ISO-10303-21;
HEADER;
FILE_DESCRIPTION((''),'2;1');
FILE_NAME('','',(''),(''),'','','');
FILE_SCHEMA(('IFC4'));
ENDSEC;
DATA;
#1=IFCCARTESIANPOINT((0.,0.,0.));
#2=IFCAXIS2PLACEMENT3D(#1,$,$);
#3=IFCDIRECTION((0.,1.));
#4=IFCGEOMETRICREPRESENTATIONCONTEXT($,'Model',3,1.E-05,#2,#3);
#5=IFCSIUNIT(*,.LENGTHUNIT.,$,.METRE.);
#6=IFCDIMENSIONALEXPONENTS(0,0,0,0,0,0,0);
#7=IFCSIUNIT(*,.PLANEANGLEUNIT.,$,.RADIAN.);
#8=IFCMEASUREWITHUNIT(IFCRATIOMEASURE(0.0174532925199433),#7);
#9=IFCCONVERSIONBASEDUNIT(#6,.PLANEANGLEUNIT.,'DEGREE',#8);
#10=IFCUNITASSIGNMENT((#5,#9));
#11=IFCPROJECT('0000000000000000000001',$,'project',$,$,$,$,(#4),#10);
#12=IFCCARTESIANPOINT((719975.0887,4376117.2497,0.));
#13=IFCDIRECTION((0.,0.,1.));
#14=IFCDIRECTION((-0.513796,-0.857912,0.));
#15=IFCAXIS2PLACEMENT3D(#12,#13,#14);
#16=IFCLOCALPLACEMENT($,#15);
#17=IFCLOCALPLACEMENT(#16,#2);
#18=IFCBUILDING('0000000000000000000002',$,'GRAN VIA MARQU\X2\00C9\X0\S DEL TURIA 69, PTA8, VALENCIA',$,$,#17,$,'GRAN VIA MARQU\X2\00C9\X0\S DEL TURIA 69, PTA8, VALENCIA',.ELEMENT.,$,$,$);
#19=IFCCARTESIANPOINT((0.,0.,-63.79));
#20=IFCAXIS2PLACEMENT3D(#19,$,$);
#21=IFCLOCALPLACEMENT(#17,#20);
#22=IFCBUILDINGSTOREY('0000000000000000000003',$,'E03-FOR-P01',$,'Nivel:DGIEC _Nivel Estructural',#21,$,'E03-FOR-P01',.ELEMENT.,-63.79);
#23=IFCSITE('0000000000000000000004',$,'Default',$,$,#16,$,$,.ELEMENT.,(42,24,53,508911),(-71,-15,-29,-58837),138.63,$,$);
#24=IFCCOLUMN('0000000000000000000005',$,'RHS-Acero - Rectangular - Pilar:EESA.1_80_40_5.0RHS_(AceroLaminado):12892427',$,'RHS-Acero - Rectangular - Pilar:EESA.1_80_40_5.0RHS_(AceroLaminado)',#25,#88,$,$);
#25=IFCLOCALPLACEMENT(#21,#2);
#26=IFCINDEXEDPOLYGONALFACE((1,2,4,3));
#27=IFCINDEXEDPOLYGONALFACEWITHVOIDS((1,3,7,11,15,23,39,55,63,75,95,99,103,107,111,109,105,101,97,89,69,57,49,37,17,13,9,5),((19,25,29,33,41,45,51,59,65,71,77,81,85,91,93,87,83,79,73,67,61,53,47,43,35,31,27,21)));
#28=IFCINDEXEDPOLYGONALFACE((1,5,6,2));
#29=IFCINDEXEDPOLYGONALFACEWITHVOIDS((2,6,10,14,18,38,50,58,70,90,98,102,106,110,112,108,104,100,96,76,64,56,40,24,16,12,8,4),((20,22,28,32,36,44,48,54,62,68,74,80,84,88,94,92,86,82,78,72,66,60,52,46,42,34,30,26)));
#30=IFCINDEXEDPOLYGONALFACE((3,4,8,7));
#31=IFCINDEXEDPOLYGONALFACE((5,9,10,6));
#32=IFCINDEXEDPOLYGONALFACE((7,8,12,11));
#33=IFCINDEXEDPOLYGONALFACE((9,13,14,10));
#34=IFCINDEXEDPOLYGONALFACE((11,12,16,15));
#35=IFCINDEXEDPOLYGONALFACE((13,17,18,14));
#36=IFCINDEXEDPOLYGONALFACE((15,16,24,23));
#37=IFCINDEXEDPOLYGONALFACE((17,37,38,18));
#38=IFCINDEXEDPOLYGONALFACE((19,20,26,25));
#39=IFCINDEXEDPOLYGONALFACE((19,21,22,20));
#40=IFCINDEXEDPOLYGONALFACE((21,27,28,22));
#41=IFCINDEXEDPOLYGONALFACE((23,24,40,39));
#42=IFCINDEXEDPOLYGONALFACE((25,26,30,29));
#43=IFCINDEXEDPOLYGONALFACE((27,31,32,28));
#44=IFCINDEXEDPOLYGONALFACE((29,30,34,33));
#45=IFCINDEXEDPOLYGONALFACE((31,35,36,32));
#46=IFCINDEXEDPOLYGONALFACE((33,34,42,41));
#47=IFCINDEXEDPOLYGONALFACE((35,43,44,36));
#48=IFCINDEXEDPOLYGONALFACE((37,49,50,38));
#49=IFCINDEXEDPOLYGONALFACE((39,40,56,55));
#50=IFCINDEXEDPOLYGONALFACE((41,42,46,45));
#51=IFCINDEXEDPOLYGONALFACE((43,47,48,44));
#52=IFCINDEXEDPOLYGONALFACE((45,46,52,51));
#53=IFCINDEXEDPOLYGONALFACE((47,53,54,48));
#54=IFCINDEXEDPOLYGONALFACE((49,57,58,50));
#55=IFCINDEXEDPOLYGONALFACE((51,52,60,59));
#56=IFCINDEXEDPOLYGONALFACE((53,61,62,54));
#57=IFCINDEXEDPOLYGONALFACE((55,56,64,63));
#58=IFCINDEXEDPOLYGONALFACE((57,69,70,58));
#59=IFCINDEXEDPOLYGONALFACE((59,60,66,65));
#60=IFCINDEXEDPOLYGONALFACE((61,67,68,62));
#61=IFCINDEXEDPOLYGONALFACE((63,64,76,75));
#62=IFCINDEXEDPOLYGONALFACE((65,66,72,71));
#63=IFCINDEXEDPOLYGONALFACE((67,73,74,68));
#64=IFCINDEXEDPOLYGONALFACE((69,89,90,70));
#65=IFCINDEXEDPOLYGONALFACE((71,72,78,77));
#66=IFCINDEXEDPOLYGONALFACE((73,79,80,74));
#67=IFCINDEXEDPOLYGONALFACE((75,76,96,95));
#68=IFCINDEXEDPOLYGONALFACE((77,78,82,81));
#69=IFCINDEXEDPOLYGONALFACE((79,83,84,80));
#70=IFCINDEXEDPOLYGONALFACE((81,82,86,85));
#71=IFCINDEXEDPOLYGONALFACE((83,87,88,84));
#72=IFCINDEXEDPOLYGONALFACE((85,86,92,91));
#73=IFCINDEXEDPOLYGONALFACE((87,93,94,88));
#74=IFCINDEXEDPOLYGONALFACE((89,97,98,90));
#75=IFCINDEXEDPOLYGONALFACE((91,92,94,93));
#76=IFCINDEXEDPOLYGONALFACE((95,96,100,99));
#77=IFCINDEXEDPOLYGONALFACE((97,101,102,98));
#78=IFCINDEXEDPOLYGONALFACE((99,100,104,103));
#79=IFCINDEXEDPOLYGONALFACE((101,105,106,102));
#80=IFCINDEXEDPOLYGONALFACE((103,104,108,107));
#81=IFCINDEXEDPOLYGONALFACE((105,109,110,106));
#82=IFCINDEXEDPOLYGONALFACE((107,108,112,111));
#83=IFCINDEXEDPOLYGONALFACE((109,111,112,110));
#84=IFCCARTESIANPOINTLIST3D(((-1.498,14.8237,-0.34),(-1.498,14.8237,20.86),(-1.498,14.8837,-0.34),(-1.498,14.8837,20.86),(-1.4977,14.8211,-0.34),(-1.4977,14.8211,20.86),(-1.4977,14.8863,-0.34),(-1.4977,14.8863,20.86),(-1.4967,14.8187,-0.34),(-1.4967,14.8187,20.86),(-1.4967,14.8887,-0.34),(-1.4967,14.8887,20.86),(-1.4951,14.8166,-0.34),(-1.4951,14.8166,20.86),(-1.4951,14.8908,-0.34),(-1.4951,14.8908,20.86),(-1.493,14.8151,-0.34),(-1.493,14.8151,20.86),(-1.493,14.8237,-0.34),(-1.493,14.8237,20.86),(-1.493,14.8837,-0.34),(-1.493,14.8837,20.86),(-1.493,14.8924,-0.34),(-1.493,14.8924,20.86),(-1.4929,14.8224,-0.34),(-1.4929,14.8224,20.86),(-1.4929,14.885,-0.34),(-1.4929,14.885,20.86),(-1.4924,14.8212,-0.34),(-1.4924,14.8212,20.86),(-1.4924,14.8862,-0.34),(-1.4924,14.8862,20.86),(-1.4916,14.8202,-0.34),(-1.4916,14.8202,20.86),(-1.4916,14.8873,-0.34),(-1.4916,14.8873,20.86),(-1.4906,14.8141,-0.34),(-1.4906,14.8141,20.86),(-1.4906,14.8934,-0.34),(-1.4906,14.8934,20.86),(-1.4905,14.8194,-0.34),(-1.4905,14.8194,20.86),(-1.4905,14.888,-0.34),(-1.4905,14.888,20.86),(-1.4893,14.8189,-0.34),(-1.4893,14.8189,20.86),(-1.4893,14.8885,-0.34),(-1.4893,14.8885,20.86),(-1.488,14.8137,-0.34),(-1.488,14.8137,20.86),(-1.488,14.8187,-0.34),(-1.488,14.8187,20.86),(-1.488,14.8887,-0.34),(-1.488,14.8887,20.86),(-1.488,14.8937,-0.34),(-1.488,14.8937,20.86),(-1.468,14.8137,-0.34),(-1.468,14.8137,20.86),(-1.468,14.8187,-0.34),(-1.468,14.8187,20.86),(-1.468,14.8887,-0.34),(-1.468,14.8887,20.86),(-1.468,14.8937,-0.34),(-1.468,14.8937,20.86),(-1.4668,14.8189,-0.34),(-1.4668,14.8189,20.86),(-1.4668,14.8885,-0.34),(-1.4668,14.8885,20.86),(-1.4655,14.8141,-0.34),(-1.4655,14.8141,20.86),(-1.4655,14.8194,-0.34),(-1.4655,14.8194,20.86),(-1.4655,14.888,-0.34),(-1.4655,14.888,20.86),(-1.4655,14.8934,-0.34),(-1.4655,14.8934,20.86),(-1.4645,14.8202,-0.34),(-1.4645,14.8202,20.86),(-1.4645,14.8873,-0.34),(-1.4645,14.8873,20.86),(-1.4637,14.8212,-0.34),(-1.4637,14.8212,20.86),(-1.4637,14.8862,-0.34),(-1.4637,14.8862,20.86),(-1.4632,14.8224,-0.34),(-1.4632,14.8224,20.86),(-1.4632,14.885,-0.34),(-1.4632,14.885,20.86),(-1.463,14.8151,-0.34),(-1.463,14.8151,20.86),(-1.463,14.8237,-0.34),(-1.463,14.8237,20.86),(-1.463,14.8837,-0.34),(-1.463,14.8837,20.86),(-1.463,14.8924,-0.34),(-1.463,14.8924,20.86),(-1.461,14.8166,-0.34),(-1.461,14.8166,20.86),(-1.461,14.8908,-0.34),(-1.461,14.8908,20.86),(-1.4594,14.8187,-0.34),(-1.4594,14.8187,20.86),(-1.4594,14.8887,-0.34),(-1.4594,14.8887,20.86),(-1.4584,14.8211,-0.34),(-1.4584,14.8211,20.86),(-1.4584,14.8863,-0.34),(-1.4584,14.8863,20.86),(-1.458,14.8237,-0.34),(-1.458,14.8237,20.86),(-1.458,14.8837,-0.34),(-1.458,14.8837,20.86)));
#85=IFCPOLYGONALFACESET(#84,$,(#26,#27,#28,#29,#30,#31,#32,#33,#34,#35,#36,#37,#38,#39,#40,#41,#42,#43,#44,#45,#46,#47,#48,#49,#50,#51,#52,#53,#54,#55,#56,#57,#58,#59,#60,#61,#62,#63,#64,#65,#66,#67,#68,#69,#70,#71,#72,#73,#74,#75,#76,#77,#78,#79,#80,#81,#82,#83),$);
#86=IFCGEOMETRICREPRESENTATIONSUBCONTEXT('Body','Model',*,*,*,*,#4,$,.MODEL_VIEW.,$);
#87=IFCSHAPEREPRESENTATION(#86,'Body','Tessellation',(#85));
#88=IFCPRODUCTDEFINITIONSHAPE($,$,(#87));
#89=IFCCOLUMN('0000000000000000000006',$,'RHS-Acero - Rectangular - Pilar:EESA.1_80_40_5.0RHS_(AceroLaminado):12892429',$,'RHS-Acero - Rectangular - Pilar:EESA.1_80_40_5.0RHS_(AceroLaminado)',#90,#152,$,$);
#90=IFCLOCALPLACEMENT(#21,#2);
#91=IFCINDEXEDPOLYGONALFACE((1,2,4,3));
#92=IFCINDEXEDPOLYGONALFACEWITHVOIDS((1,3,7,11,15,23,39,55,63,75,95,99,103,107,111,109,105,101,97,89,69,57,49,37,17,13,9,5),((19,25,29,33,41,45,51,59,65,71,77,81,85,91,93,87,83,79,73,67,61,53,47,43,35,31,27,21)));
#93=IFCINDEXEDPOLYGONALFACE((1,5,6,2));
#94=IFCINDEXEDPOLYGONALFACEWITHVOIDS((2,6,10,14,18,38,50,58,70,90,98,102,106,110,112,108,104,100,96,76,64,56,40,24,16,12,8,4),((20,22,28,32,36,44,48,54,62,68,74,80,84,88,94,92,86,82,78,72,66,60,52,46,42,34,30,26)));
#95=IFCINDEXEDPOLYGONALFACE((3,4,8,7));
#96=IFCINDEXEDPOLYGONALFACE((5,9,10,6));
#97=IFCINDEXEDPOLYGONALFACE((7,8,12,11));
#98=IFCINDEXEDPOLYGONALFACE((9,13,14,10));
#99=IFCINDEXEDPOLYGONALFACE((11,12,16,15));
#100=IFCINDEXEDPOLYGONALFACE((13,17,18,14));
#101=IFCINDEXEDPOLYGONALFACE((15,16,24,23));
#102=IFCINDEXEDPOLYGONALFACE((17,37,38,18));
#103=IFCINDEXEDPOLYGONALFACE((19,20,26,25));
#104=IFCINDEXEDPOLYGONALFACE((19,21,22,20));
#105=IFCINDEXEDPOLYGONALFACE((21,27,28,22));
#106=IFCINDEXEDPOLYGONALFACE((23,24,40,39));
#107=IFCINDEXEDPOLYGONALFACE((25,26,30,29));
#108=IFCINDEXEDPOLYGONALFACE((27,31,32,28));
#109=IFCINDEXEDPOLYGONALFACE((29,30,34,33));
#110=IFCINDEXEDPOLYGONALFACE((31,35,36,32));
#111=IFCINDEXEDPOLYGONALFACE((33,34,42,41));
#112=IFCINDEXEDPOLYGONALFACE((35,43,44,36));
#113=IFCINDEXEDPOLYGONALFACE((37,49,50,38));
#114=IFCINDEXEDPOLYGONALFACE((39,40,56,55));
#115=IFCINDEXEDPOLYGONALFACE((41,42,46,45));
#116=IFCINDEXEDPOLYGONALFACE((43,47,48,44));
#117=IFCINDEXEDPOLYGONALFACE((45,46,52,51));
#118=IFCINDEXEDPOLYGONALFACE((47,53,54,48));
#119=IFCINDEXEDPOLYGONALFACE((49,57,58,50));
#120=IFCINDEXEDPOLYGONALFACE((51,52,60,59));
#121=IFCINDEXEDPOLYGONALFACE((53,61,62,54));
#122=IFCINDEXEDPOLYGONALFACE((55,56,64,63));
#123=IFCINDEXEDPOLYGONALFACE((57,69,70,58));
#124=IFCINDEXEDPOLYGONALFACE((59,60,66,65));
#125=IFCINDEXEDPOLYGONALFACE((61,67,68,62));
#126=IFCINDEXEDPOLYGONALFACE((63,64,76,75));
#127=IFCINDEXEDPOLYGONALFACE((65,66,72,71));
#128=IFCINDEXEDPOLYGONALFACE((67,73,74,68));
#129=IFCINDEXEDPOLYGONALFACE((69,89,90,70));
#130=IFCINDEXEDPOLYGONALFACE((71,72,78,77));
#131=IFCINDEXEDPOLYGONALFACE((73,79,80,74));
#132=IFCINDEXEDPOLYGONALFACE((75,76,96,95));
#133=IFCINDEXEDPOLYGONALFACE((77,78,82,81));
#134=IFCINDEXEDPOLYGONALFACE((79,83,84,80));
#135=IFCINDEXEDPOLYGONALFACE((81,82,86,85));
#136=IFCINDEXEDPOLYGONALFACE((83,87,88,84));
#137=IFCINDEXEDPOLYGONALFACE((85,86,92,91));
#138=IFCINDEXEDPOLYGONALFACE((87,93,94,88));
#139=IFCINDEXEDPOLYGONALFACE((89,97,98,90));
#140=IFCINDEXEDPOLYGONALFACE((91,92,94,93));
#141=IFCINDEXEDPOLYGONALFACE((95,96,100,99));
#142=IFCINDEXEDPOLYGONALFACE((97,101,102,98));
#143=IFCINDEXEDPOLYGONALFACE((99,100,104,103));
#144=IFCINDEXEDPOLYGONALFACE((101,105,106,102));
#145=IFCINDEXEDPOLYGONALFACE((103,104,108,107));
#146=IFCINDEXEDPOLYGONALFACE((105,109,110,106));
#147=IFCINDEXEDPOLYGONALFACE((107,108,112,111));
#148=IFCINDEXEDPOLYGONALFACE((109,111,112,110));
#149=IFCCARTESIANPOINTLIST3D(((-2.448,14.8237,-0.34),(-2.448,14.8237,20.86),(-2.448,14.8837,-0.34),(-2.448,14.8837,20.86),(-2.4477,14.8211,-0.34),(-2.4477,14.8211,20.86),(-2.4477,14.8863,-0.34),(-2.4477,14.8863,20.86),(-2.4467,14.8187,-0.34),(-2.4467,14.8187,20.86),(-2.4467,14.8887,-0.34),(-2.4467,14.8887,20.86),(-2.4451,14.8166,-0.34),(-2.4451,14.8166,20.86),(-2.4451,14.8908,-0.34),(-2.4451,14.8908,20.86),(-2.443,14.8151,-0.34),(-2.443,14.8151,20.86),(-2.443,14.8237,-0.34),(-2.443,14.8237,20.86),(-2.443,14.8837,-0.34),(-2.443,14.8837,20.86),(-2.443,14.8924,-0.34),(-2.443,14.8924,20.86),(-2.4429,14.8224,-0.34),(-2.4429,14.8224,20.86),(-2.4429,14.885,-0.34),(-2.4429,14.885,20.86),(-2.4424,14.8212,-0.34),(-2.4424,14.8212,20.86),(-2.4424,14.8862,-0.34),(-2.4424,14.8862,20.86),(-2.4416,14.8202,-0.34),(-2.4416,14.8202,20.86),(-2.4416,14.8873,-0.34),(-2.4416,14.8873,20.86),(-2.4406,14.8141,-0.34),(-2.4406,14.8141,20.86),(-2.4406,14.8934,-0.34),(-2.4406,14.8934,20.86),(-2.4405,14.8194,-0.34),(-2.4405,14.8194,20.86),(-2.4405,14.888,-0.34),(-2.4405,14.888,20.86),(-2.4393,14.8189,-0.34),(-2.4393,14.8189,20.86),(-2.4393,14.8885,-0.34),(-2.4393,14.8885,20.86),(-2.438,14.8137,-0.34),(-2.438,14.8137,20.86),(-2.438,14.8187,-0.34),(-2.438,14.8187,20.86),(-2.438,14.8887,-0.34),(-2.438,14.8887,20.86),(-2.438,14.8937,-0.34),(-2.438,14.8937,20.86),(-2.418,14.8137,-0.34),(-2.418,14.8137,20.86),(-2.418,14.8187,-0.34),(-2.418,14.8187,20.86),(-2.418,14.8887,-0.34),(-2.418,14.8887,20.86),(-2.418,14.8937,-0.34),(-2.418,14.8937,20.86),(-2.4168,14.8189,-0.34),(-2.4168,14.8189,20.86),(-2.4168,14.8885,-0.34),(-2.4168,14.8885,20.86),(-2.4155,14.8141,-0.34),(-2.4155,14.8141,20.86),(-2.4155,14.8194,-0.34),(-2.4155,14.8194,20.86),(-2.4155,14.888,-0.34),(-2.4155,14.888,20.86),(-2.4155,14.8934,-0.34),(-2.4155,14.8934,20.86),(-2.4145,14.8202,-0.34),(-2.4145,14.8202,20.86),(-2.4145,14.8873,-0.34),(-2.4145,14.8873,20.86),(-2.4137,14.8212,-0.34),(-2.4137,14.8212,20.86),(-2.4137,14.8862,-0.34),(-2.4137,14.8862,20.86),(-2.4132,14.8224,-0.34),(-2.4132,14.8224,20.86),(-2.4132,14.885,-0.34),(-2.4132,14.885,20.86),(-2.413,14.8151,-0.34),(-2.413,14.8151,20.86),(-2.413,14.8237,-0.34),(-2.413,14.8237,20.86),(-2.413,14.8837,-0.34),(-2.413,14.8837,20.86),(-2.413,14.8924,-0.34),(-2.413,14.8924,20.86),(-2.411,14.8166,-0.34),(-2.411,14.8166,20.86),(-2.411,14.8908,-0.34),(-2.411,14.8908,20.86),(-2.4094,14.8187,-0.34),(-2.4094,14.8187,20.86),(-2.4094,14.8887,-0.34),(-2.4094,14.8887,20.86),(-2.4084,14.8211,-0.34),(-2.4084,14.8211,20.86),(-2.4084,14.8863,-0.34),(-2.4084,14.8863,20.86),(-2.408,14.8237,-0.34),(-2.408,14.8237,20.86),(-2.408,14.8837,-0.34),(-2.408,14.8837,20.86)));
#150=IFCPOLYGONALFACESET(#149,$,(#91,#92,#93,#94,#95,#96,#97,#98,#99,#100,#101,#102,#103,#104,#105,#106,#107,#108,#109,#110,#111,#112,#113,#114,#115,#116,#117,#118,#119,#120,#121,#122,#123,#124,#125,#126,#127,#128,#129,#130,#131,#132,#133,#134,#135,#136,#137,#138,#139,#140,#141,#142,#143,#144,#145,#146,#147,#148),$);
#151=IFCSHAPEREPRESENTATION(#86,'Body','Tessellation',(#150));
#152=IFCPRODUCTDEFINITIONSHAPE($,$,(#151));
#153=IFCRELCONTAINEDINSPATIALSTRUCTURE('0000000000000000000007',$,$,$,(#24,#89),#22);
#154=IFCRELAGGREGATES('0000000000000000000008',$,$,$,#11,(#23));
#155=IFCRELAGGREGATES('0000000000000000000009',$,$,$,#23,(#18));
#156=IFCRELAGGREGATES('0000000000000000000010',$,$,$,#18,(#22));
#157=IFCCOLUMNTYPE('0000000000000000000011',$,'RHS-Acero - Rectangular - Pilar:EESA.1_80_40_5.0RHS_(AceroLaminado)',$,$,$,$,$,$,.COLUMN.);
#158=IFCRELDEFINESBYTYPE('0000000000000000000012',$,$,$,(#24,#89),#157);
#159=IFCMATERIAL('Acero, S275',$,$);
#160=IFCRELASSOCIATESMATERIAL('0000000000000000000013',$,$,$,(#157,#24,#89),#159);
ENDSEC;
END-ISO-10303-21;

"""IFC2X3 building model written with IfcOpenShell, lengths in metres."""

from ifc_helpers import new_model, entity, si_unit, converted_unit, direction, frame, frame_2d, origin, place, context, subcontext, project, spatial, polyline, circle_curve, parameter, trimmed, segment, composite_curve, outline, extrude, source, transform, mapped, material, type_object, type_shapes, element, save


model = new_model("IFC2X3")

# Units and contexts
model_context = context("Model", 3, precision=1e-05, world=origin(), true_north=direction((0.0, 1.0)))
body_context = subcontext(model_context, "Body", "Model", "MODEL_VIEW")
ifc_project = project(units=[si_unit("LENGTHUNIT", "METRE"), converted_unit("PLANEANGLEUNIT", "DEGREE", entity("IfcRatioMeasure", 0.0174532925199433), si_unit("PLANEANGLEUNIT", "RADIAN"), dimensions=[0, 0, 0, 0, 0, 0, 0])], contexts=[model_context])

# Site, building, storey
site_placement = place(None, frame((719975.0887, 4376117.2497, 0.0), z_axis=(0.0, 0.0, 1.0), x_axis=(-0.513796, -0.857912, 0.0)))
site = spatial("IfcSite", under=ifc_project, at=site_placement, Name="Default", CompositionType="ELEMENT", RefLatitude=(42, 24, 53, 508911), RefLongitude=(-71, -15, -29, -58837), RefElevation=138.63)
building_placement = place(site_placement, origin())
building = spatial("IfcBuilding", under=site, at=building_placement, Name="GRAN VIA MARQUÉS DEL TURIA 69, PTA8, VALENCIA", LongName="GRAN VIA MARQUÉS DEL TURIA 69, PTA8, VALENCIA", CompositionType="ELEMENT")
storey_placement = place(building_placement, frame((0.0, 0.0, -63.79)))
storey = spatial("IfcBuildingStorey", under=building, at=storey_placement, Name="E03-FOR-P01", ObjectType="Nivel:DGIEC _Nivel Estructural", LongName="E03-FOR-P01", CompositionType="ELEMENT", Elevation=-63.79)

# Columns
ifc_material_1 = material(Name="Acero, S275")
column_type_1 = type_object("IfcColumnType", Name="RHS-Acero - Rectangular - Pilar:EESA.1_80_40_5.0RHS_(AceroLaminado)", PredefinedType="COLUMN", material=ifc_material_1)
shared_shape_1 = source(origin(), body_context, "Body", "SweptSolid", [
    extrude(outline(composite_curve([segment(polyline([(-0.01, -0.04), (0.01, -0.04)]), True, "CONTINUOUS"), segment(trimmed(circle_curve(frame_2d((0.01, -0.03), x_axis=(-1.0, 0.0)), 0.01), [parameter(90.0)], [parameter(180.0)], True, "PARAMETER"), True, "CONTINUOUS"), segment(polyline([(0.02, -0.03), (0.02, 0.03)]), True, "CONTINUOUS"), segment(trimmed(circle_curve(frame_2d((0.01, 0.03), x_axis=(-1.0, 0.0)), 0.01), [parameter(180.0)], [parameter(270.0)], True, "PARAMETER"), True, "CONTINUOUS"), segment(polyline([(0.01, 0.04), (-0.01, 0.04)]), True, "CONTINUOUS"), segment(trimmed(circle_curve(frame_2d((-0.01, 0.03), x_axis=(-1.0, 0.0)), 0.01), [parameter(270.0)], [parameter(360.0)], True, "PARAMETER"), True, "CONTINUOUS"), segment(polyline([(-0.02, 0.03), (-0.02, -0.03)]), True, "CONTINUOUS"), segment(trimmed(circle_curve(frame_2d((-0.01, -0.03), x_axis=(-1.0, 0.0)), 0.01), [parameter(360.0)], [parameter(90.0)], True, "PARAMETER"), True, "CONTINUOUS")], self_intersect=False), holes=[composite_curve([segment(trimmed(circle_curve(frame_2d((-0.01, -0.03), x_axis=(-1.0, 0.0)), 0.005), [parameter(0.0)], [parameter(90.0)], True, "PARAMETER"), False, "CONTINUOUS"), segment(polyline([(-0.015, -0.03), (-0.015, 0.03)]), True, "CONTINUOUS"), segment(trimmed(circle_curve(frame_2d((-0.01, 0.03), x_axis=(-1.0, 0.0)), 0.005), [parameter(270.0)], [parameter(0.0)], True, "PARAMETER"), False, "CONTINUOUS"), segment(polyline([(-0.01, 0.035), (0.01, 0.035)]), True, "CONTINUOUS"), segment(trimmed(circle_curve(frame_2d((0.01, 0.03), x_axis=(-1.0, 0.0)), 0.005), [parameter(180.0)], [parameter(270.0)], True, "PARAMETER"), False, "CONTINUOUS"), segment(polyline([(0.015, 0.03), (0.015, -0.03)]), True, "CONTINUOUS"), segment(trimmed(circle_curve(frame_2d((0.01, -0.03), x_axis=(-1.0, 0.0)), 0.005), [parameter(90.0)], [parameter(180.0)], True, "PARAMETER"), False, "CONTINUOUS"), segment(polyline([(0.01, -0.035), (-0.01, -0.035)]), True, "CONTINUOUS")], self_intersect=False)]), frame((0.0, 0.0, -64.13), z_axis=(0.0, 0.0, 1.0), x_axis=(-1.0, 0.0, 0.0)), (0.0, 0.0, 1.0), 21.2),
])
type_shapes(column_type_1, [shared_shape_1])
for number, where, z_axis, x_axis, name in (
    (1, (-1.478, 14.8537, 63.79), (0.0, 0.0, 1.0), (-1.0, 0.0, 0.0), "RHS-Acero - Rectangular - Pilar:EESA.1_80_40_5.0RHS_(AceroLaminado):12892427"),
    (2, (-2.428, 14.8537, 63.79), (0.0, 0.0, 1.0), (-1.0, 0.0, 0.0), "RHS-Acero - Rectangular - Pilar:EESA.1_80_40_5.0RHS_(AceroLaminado):12892429"),
):
    element("IfcColumn", number, at=place(storey_placement, frame(where, z_axis=z_axis, x_axis=x_axis)), inside=storey, type_object=column_type_1, material=ifc_material_1, Name=name, ObjectType="RHS-Acero - Rectangular - Pilar:EESA.1_80_40_5.0RHS_(AceroLaminado)", context=body_context, shape_type="MappedRepresentation", body=[
        mapped(shared_shape_1, transform((0.0, 0.0, 0.0), scale=1.0)),
    ])

save(model, "model.ifc")
